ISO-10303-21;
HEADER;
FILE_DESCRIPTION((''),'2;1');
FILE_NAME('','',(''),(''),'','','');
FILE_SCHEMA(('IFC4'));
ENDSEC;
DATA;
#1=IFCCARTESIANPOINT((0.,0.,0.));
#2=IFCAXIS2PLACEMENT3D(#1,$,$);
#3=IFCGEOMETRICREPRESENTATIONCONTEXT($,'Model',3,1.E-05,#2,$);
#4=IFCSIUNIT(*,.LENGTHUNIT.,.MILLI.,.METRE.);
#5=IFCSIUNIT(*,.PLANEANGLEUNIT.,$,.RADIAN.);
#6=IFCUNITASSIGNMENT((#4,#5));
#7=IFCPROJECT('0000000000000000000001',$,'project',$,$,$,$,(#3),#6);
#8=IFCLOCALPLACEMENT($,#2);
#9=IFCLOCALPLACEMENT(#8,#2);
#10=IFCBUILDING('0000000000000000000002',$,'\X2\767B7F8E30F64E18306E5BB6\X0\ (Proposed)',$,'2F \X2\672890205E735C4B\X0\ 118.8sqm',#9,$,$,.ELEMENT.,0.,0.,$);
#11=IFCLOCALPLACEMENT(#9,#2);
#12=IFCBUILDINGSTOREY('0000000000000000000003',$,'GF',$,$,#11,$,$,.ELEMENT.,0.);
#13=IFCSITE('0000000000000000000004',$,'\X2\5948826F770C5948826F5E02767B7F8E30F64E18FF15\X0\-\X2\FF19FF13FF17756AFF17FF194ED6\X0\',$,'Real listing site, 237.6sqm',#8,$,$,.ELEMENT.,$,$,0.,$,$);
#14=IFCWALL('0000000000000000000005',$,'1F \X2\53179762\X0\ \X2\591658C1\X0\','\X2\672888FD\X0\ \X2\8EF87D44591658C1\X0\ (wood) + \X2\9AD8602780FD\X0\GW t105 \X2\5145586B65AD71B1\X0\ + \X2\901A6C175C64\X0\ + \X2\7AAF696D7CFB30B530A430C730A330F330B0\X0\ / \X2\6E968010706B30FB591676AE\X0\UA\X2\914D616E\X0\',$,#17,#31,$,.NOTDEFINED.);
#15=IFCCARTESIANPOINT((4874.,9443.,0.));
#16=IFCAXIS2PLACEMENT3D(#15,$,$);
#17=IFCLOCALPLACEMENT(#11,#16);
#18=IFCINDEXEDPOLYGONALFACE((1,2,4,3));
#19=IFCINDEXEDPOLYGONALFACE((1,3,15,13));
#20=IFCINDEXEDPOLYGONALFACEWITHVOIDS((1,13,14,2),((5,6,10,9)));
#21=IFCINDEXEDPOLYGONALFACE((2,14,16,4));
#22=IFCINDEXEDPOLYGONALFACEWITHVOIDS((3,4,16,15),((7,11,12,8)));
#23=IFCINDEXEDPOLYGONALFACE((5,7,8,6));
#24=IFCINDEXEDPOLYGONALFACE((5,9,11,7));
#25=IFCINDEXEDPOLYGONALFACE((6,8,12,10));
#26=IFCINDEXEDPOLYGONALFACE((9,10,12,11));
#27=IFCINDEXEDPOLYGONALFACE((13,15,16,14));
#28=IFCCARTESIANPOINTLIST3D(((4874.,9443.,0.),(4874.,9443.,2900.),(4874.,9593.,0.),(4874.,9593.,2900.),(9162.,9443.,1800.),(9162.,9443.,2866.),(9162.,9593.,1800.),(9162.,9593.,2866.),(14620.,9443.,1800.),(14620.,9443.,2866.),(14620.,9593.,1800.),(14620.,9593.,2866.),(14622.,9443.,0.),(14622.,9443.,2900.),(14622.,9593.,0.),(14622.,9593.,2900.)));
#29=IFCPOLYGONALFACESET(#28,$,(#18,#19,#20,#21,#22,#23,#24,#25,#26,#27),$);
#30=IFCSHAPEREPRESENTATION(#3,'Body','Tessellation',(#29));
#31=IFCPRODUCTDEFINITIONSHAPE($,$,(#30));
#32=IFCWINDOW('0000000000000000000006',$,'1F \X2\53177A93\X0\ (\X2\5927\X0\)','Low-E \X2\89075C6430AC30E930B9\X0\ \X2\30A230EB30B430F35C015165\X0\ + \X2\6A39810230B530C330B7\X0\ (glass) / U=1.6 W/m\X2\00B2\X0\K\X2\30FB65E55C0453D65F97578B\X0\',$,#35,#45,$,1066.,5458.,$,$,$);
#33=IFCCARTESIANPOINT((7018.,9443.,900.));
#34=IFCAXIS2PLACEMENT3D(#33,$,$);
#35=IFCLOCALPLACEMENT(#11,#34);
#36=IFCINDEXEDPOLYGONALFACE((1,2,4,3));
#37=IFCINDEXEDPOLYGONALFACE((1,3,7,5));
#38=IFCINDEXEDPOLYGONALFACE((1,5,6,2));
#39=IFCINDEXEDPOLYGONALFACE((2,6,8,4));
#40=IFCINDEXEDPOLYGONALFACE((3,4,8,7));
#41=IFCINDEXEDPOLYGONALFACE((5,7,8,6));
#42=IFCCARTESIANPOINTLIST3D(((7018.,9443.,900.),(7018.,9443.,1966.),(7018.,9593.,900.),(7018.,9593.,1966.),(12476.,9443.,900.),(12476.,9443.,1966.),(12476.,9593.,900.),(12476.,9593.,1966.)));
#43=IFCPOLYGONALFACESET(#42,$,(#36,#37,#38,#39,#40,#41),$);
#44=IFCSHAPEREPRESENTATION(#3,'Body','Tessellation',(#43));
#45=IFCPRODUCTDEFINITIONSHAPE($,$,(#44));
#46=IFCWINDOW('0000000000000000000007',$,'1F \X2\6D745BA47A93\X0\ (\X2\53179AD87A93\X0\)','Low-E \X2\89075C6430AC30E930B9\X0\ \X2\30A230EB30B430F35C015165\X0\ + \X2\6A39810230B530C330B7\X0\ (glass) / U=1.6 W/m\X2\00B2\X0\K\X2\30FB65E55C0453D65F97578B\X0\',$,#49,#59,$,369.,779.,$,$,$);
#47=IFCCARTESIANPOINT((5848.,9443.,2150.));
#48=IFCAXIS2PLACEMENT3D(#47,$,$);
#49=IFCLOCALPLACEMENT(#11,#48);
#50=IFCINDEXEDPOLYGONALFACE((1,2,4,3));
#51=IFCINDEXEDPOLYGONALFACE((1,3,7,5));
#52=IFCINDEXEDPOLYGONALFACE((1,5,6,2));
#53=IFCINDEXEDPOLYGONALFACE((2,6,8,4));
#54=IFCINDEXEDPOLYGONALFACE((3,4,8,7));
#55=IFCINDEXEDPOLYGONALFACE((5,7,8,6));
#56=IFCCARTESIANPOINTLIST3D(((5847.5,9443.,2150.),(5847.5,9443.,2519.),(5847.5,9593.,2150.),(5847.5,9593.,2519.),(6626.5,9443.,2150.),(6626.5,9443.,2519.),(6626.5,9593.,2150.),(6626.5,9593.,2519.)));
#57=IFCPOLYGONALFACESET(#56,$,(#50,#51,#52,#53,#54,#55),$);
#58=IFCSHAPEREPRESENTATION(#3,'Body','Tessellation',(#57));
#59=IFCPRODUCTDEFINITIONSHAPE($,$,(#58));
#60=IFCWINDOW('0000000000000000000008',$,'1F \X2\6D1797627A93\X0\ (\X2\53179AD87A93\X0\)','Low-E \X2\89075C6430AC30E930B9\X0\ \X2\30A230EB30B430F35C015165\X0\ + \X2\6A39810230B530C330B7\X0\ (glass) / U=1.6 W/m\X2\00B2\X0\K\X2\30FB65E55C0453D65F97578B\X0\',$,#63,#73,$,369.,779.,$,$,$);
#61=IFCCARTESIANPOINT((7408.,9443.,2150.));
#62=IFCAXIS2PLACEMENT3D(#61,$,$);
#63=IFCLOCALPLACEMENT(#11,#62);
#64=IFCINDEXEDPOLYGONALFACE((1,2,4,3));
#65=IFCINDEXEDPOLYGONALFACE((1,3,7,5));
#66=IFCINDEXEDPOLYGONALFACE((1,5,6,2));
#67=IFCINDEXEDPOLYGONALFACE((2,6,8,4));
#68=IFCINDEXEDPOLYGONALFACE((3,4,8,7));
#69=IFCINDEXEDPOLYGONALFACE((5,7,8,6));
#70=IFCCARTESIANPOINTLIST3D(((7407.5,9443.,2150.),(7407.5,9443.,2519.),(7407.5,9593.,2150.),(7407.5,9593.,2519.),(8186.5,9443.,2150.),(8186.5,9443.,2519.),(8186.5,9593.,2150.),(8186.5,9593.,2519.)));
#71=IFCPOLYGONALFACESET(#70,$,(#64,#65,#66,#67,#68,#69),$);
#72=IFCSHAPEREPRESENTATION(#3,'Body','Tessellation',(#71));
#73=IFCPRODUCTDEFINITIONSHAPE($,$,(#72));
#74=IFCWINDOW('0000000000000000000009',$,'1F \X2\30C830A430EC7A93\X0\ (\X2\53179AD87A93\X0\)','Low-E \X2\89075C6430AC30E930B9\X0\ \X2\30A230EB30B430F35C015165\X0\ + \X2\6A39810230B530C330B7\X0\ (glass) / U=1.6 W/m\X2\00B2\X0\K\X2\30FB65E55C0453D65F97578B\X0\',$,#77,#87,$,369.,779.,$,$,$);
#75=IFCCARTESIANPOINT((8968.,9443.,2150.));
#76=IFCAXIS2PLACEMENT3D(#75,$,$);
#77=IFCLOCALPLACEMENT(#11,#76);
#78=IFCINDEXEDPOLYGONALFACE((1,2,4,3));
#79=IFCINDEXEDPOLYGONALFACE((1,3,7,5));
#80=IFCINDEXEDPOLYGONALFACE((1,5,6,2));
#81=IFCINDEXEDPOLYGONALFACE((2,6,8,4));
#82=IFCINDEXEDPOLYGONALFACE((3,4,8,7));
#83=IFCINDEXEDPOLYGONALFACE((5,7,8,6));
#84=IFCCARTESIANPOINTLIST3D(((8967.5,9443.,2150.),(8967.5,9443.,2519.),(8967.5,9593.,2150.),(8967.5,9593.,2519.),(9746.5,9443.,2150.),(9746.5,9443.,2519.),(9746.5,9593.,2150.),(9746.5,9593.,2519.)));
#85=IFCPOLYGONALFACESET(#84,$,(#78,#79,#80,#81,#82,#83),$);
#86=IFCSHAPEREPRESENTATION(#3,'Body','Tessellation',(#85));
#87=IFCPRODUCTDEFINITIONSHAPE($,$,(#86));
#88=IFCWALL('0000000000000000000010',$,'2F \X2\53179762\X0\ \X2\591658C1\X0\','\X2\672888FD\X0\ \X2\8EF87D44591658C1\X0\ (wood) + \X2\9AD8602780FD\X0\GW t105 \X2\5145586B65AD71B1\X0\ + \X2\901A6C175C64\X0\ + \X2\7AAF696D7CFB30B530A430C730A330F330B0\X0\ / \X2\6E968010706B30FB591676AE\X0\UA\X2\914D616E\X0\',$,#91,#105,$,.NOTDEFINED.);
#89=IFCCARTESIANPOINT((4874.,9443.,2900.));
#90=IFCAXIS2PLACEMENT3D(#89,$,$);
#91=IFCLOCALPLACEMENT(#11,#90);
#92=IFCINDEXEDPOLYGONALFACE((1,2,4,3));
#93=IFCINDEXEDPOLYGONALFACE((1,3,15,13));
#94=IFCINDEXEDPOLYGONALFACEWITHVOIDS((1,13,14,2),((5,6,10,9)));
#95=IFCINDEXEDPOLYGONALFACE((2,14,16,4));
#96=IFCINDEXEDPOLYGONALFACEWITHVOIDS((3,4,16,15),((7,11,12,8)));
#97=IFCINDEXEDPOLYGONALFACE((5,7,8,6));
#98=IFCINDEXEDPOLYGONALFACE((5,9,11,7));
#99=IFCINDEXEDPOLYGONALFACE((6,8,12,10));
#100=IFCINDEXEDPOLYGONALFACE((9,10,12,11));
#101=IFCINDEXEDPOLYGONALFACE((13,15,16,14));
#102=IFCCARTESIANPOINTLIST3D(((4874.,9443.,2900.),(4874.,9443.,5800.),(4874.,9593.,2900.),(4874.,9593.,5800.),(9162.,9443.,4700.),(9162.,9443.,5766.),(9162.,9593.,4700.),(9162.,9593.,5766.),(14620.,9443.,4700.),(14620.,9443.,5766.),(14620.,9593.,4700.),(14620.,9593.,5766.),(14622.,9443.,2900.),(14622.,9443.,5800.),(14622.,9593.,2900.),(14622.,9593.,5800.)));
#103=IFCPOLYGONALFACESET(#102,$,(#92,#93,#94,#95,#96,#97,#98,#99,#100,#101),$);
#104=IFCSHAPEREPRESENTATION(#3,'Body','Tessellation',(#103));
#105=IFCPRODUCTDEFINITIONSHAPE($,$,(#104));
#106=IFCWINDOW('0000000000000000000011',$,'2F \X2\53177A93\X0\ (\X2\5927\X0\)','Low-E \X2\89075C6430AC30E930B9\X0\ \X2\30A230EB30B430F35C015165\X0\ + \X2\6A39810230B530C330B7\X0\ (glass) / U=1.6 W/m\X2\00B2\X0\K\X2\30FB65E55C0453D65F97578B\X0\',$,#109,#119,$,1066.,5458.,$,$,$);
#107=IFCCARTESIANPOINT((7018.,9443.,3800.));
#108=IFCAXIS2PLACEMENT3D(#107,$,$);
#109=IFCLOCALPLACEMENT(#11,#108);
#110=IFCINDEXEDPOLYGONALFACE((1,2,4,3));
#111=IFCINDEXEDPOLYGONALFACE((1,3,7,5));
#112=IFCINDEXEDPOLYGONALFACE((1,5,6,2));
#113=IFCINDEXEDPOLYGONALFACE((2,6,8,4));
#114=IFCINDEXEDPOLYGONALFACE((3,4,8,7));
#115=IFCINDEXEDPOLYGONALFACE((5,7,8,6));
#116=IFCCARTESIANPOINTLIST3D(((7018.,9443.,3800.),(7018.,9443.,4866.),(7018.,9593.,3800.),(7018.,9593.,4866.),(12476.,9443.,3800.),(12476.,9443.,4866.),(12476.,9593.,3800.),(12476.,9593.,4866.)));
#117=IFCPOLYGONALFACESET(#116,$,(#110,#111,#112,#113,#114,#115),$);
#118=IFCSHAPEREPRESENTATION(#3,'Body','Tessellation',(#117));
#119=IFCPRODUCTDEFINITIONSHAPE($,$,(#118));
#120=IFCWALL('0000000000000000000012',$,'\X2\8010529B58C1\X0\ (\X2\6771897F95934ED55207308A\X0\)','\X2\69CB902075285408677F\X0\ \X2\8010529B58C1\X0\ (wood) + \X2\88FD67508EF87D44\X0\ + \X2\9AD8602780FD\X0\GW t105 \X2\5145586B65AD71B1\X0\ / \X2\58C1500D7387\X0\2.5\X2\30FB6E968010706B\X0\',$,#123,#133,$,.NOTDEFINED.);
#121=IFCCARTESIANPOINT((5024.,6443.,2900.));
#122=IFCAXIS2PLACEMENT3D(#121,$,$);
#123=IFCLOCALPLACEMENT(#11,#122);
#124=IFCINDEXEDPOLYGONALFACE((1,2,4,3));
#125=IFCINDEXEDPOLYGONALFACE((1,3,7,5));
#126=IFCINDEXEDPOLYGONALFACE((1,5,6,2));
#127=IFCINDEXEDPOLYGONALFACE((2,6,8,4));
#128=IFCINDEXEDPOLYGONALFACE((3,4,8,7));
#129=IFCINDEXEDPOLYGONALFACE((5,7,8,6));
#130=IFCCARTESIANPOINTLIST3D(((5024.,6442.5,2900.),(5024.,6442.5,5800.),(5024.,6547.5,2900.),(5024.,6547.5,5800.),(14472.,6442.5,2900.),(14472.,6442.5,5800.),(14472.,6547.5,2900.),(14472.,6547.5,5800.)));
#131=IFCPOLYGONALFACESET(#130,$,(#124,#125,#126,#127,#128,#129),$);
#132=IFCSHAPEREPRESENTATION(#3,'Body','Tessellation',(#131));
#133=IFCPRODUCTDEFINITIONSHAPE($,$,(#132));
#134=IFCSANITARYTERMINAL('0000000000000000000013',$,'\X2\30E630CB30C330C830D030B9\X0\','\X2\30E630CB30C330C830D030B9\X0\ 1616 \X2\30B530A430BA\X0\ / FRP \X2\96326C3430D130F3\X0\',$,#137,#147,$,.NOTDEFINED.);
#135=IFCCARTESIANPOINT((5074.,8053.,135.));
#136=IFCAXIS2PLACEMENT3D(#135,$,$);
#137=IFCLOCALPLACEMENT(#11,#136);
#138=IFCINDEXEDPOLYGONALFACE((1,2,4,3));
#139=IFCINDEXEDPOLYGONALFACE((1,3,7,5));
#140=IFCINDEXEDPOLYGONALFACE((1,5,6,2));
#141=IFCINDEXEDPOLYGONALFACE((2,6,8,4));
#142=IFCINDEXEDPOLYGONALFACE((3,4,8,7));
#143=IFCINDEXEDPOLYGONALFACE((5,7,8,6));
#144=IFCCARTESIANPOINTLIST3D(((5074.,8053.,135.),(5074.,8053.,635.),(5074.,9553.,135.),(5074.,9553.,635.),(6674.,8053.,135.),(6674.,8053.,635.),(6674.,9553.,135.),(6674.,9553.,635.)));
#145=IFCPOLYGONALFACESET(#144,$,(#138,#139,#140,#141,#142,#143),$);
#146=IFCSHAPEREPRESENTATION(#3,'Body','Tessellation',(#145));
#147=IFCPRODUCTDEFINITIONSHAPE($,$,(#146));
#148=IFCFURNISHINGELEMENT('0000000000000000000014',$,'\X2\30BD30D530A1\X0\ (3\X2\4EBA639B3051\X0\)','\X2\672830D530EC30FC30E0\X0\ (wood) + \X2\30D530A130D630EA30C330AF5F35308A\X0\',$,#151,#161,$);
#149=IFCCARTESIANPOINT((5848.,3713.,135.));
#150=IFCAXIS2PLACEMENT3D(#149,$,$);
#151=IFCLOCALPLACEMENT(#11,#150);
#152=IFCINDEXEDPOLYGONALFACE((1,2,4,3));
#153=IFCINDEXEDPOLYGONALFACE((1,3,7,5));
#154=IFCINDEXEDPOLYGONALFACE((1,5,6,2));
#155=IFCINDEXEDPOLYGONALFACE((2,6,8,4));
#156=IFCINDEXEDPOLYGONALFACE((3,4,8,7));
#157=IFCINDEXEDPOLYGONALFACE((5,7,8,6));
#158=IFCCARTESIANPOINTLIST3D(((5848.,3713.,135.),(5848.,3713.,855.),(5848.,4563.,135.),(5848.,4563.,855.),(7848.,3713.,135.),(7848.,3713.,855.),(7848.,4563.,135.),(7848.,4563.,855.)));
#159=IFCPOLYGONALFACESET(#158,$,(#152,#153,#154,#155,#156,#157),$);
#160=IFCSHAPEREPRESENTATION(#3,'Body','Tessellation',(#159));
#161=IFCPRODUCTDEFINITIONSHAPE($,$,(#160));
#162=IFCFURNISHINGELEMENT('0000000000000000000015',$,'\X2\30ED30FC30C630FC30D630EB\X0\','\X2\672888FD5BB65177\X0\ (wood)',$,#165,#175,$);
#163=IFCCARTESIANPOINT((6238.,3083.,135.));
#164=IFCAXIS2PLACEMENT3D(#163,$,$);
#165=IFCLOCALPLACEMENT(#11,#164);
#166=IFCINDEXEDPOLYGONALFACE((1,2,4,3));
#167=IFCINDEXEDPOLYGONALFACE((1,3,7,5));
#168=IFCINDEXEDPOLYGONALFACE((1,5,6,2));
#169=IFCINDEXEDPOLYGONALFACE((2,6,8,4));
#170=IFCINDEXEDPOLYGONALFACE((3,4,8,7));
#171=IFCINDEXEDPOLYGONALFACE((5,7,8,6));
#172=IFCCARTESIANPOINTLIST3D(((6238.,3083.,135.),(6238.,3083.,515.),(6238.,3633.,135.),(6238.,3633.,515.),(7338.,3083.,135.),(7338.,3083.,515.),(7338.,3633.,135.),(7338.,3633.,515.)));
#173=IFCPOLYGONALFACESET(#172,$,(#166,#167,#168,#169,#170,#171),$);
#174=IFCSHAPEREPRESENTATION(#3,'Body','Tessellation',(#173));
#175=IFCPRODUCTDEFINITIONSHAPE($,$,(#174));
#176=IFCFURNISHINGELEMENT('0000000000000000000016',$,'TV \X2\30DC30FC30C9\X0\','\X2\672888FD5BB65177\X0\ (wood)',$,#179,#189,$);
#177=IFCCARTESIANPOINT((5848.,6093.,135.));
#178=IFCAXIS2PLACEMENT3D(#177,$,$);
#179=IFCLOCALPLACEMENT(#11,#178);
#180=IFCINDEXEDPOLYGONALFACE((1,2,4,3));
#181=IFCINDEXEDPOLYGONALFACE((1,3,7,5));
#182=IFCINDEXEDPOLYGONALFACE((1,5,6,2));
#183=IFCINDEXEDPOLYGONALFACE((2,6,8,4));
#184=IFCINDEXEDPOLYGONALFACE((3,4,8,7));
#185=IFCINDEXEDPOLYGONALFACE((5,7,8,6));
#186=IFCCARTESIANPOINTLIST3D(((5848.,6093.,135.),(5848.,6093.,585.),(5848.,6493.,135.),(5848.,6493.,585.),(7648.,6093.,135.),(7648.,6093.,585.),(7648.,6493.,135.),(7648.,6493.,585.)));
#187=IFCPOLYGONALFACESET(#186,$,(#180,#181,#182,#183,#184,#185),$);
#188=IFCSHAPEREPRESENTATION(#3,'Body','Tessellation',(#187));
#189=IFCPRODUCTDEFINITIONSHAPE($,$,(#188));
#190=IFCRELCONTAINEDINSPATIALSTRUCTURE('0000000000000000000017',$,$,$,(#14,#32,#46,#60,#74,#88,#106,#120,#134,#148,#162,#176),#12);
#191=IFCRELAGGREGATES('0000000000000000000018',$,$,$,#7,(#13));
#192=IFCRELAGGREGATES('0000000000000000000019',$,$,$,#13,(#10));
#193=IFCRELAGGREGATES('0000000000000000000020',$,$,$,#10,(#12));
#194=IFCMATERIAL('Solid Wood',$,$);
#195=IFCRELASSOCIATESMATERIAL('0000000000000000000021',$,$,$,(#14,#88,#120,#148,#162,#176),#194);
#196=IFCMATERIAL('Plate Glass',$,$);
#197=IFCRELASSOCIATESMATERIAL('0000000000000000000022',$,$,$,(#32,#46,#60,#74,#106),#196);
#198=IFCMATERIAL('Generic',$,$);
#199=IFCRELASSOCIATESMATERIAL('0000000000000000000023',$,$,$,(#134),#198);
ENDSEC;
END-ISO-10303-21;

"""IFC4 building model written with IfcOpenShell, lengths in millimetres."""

from ifc_helpers import new_model, si_unit, frame, frame_2d, origin, place, context, project, spatial, rectangle, extrude, material, element, fill, save


model = new_model("IFC4")

# Units and contexts
model_context = context("Model", 3, precision=1e-05, world=origin())
ifc_project = project(units=[si_unit("LENGTHUNIT", "METRE", prefix="MILLI"), si_unit("PLANEANGLEUNIT", "RADIAN")], contexts=[model_context])

# Site, building, storey
site_placement = place(None, origin())
site = spatial("IfcSite", under=ifc_project, at=site_placement, Name="奈良県奈良市登美ヶ丘５-９３７番７９他", ObjectType="Real listing site, 237.6sqm", CompositionType="ELEMENT", RefElevation=0.0)
building_placement = place(site_placement, origin())
building = spatial("IfcBuilding", under=site, at=building_placement, Name="登美ヶ丘の家 (Proposed)", ObjectType="2F 木造平屋 118.8sqm", CompositionType="ELEMENT", ElevationOfRefHeight=0.0, ElevationOfTerrain=0.0)
storey_placement = place(building_placement, origin())
storey = spatial("IfcBuildingStorey", under=building, at=storey_placement, Name="GF", CompositionType="ELEMENT", Elevation=0.0)

# Wall, openings, windows
ifc_material_1 = material(Name="Solid Wood")
wall_1_placement = place(storey_placement, frame((4874.0, 9443.0, 0.0)))
wall_1 = element("IfcWall", 1, at=wall_1_placement, inside=storey, material=ifc_material_1, Name="1F 北面 外壁", Description="木製 軸組外壁 (wood) + 高性能GW t105 充填断熱 + 通気層 + 窯業系サイディング / 準耐火・外皮UA配慮", PredefinedType="NOTDEFINED", context=model_context, shape_type="SweptSolid", body=[
    extrude(rectangle(XDim=9748.0, YDim=150.0, at=frame_2d((4874.0, 75.0))), frame((4874.0, 9443.0, 0.0)), (0.0, 0.0, 1.0), 2900.0),
])
opening_1_placement = place(storey_placement, frame((7018.0, 9443.0, 900.0)))
opening_1 = element("IfcOpeningElement", 2, at=opening_1_placement, cuts=wall_1, PredefinedType="NOTDEFINED", context=model_context, shape_type="SweptSolid", body=[
    extrude(rectangle(XDim=5458.0, YDim=150.0, at=frame_2d((2729.0, 75.0))), frame((7018.0, 9443.0, 900.0)), (0.0, 0.0, 1.0), 1066.0),
])
opening_2_placement = place(storey_placement, frame((5848.0, 9443.0, 2150.0)))
opening_2 = element("IfcOpeningElement", 3, at=opening_2_placement, cuts=wall_1, PredefinedType="NOTDEFINED", context=model_context, shape_type="SweptSolid", body=[
    extrude(rectangle(XDim=779.0, YDim=150.0, at=frame_2d((389.0, 75.0))), frame((5848.0, 9443.0, 2150.0)), (0.0, 0.0, 1.0), 369.0),
])
opening_3_placement = place(storey_placement, frame((7408.0, 9443.0, 2150.0)))
opening_3 = element("IfcOpeningElement", 4, at=opening_3_placement, cuts=wall_1, PredefinedType="NOTDEFINED", context=model_context, shape_type="SweptSolid", body=[
    extrude(rectangle(XDim=779.0, YDim=150.0, at=frame_2d((389.0, 75.0))), frame((7408.0, 9443.0, 2150.0)), (0.0, 0.0, 1.0), 369.0),
])
opening_4_placement = place(storey_placement, frame((8968.0, 9443.0, 2150.0)))
opening_4 = element("IfcOpeningElement", 5, at=opening_4_placement, cuts=wall_1, PredefinedType="NOTDEFINED", context=model_context, shape_type="SweptSolid", body=[
    extrude(rectangle(XDim=779.0, YDim=150.0, at=frame_2d((389.0, 75.0))), frame((8968.0, 9443.0, 2150.0)), (0.0, 0.0, 1.0), 369.0),
])
ifc_material_2 = material(Name="Plate Glass")
window_1_placement = place(storey_placement, frame((7018.0, 9443.0, 900.0)))
window_1 = element("IfcWindow", 6, at=window_1_placement, inside=storey, material=ifc_material_2, Name="1F 北窓 (大)", Description="Low-E 複層ガラス アルゴン封入 + 樹脂サッシ (glass) / U=1.6 W/m²K・日射取得型", OverallHeight=1066.0, OverallWidth=5458.0, context=model_context, shape_type="SweptSolid", body=[
    extrude(rectangle(XDim=5458.0, YDim=150.0, at=frame_2d((2729.0, 75.0))), frame((7018.0, 9443.0, 900.0)), (0.0, 0.0, 1.0), 1066.0),
])
fill(opening_1, window_1)
window_2_placement = place(storey_placement, frame((5848.0, 9443.0, 2150.0)))
window_2 = element("IfcWindow", 7, at=window_2_placement, inside=storey, material=ifc_material_2, Name="1F 浴室窓 (北高窓)", Description="Low-E 複層ガラス アルゴン封入 + 樹脂サッシ (glass) / U=1.6 W/m²K・日射取得型", OverallHeight=369.0, OverallWidth=779.0, context=model_context, shape_type="SweptSolid", body=[
    extrude(rectangle(XDim=779.0, YDim=150.0, at=frame_2d((389.0, 75.0))), frame((5848.0, 9443.0, 2150.0)), (0.0, 0.0, 1.0), 369.0),
])
fill(opening_2, window_2)
window_3_placement = place(storey_placement, frame((7408.0, 9443.0, 2150.0)))
window_3 = element("IfcWindow", 8, at=window_3_placement, inside=storey, material=ifc_material_2, Name="1F 洗面窓 (北高窓)", Description="Low-E 複層ガラス アルゴン封入 + 樹脂サッシ (glass) / U=1.6 W/m²K・日射取得型", OverallHeight=369.0, OverallWidth=779.0, context=model_context, shape_type="SweptSolid", body=[
    extrude(rectangle(XDim=779.0, YDim=150.0, at=frame_2d((389.0, 75.0))), frame((7408.0, 9443.0, 2150.0)), (0.0, 0.0, 1.0), 369.0),
])
fill(opening_3, window_3)
window_4_placement = place(storey_placement, frame((8968.0, 9443.0, 2150.0)))
window_4 = element("IfcWindow", 9, at=window_4_placement, inside=storey, material=ifc_material_2, Name="1F トイレ窓 (北高窓)", Description="Low-E 複層ガラス アルゴン封入 + 樹脂サッシ (glass) / U=1.6 W/m²K・日射取得型", OverallHeight=369.0, OverallWidth=779.0, context=model_context, shape_type="SweptSolid", body=[
    extrude(rectangle(XDim=779.0, YDim=150.0, at=frame_2d((389.0, 75.0))), frame((8968.0, 9443.0, 2150.0)), (0.0, 0.0, 1.0), 369.0),
])
fill(opening_4, window_4)

# Wall, opening, window
wall_2_placement = place(storey_placement, frame((4874.0, 9443.0, 2900.0)))
wall_2 = element("IfcWall", 10, at=wall_2_placement, inside=storey, material=ifc_material_1, Name="2F 北面 外壁", Description="木製 軸組外壁 (wood) + 高性能GW t105 充填断熱 + 通気層 + 窯業系サイディング / 準耐火・外皮UA配慮", PredefinedType="NOTDEFINED", context=model_context, shape_type="SweptSolid", body=[
    extrude(rectangle(XDim=9748.0, YDim=150.0, at=frame_2d((4874.0, 75.0))), frame((4874.0, 9443.0, 2900.0)), (0.0, 0.0, 1.0), 2900.0),
])
opening_5_placement = place(storey_placement, frame((7018.0, 9443.0, 3800.0)))
opening_5 = element("IfcOpeningElement", 11, at=opening_5_placement, cuts=wall_2, PredefinedType="NOTDEFINED", context=model_context, shape_type="SweptSolid", body=[
    extrude(rectangle(XDim=5458.0, YDim=150.0, at=frame_2d((2729.0, 75.0))), frame((7018.0, 9443.0, 3800.0)), (0.0, 0.0, 1.0), 1066.0),
])
window_5_placement = place(storey_placement, frame((7018.0, 9443.0, 3800.0)))
window_5 = element("IfcWindow", 12, at=window_5_placement, inside=storey, material=ifc_material_2, Name="2F 北窓 (大)", Description="Low-E 複層ガラス アルゴン封入 + 樹脂サッシ (glass) / U=1.6 W/m²K・日射取得型", OverallHeight=1066.0, OverallWidth=5458.0, context=model_context, shape_type="SweptSolid", body=[
    extrude(rectangle(XDim=5458.0, YDim=150.0, at=frame_2d((2729.0, 75.0))), frame((7018.0, 9443.0, 3800.0)), (0.0, 0.0, 1.0), 1066.0),
])
fill(opening_5, window_5)

# Wall
wall_3_placement = place(storey_placement, frame((5024.0, 6443.0, 2900.0)))
element("IfcWall", 13, at=wall_3_placement, inside=storey, material=ifc_material_1, Name="耐力壁 (東西間仕切り)", Description="構造用合板 耐力壁 (wood) + 製材軸組 + 高性能GW t105 充填断熱 / 壁倍率2.5・準耐火", PredefinedType="NOTDEFINED", context=model_context, shape_type="SweptSolid", body=[
    extrude(rectangle(XDim=9448.0, YDim=105.0, at=frame_2d((4724.0, 52.0))), frame((5024.0, 6443.0, 2900.0)), (0.0, 0.0, 1.0), 2900.0),
])

# Sanitary terminal
ifc_material_3 = material(Name="Generic")
sanitary_terminal_placement = place(storey_placement, frame((5074.0, 8053.0, 135.0)))
element("IfcSanitaryTerminal", 14, at=sanitary_terminal_placement, inside=storey, material=ifc_material_3, Name="ユニットバス", Description="ユニットバス 1616 サイズ / FRP 防水パン", PredefinedType="NOTDEFINED", context=model_context, shape_type="SweptSolid", body=[
    extrude(rectangle(XDim=1600.0, YDim=1500.0, at=frame_2d((800.0, 750.0))), frame((5074.0, 8053.0, 135.0)), (0.0, 0.0, 1.0), 500.0),
])

# Furnishing elements
furnishing_1_placement = place(storey_placement, frame((5848.0, 3713.0, 135.0)))
element("IfcFurnishingElement", 15, at=furnishing_1_placement, inside=storey, material=ifc_material_1, Name="ソファ (3人掛け)", Description="木フレーム (wood) + ファブリック張り", context=model_context, shape_type="SweptSolid", body=[
    extrude(rectangle(XDim=2000.0, YDim=850.0, at=frame_2d((1000.0, 425.0))), frame((5848.0, 3713.0, 135.0)), (0.0, 0.0, 1.0), 720.0),
])
furnishing_2_placement = place(storey_placement, frame((6238.0, 3083.0, 135.0)))
element("IfcFurnishingElement", 16, at=furnishing_2_placement, inside=storey, material=ifc_material_1, Name="ローテーブル", Description="木製家具 (wood)", context=model_context, shape_type="SweptSolid", body=[
    extrude(rectangle(XDim=1100.0, YDim=550.0, at=frame_2d((550.0, 275.0))), frame((6238.0, 3083.0, 135.0)), (0.0, 0.0, 1.0), 380.0),
])
furnishing_3_placement = place(storey_placement, frame((5848.0, 6093.0, 135.0)))
element("IfcFurnishingElement", 17, at=furnishing_3_placement, inside=storey, material=ifc_material_1, Name="TV ボード", Description="木製家具 (wood)", context=model_context, shape_type="SweptSolid", body=[
    extrude(rectangle(XDim=1800.0, YDim=400.0, at=frame_2d((900.0, 200.0))), frame((5848.0, 6093.0, 135.0)), (0.0, 0.0, 1.0), 450.0),
])

save(model, "model.ifc")
